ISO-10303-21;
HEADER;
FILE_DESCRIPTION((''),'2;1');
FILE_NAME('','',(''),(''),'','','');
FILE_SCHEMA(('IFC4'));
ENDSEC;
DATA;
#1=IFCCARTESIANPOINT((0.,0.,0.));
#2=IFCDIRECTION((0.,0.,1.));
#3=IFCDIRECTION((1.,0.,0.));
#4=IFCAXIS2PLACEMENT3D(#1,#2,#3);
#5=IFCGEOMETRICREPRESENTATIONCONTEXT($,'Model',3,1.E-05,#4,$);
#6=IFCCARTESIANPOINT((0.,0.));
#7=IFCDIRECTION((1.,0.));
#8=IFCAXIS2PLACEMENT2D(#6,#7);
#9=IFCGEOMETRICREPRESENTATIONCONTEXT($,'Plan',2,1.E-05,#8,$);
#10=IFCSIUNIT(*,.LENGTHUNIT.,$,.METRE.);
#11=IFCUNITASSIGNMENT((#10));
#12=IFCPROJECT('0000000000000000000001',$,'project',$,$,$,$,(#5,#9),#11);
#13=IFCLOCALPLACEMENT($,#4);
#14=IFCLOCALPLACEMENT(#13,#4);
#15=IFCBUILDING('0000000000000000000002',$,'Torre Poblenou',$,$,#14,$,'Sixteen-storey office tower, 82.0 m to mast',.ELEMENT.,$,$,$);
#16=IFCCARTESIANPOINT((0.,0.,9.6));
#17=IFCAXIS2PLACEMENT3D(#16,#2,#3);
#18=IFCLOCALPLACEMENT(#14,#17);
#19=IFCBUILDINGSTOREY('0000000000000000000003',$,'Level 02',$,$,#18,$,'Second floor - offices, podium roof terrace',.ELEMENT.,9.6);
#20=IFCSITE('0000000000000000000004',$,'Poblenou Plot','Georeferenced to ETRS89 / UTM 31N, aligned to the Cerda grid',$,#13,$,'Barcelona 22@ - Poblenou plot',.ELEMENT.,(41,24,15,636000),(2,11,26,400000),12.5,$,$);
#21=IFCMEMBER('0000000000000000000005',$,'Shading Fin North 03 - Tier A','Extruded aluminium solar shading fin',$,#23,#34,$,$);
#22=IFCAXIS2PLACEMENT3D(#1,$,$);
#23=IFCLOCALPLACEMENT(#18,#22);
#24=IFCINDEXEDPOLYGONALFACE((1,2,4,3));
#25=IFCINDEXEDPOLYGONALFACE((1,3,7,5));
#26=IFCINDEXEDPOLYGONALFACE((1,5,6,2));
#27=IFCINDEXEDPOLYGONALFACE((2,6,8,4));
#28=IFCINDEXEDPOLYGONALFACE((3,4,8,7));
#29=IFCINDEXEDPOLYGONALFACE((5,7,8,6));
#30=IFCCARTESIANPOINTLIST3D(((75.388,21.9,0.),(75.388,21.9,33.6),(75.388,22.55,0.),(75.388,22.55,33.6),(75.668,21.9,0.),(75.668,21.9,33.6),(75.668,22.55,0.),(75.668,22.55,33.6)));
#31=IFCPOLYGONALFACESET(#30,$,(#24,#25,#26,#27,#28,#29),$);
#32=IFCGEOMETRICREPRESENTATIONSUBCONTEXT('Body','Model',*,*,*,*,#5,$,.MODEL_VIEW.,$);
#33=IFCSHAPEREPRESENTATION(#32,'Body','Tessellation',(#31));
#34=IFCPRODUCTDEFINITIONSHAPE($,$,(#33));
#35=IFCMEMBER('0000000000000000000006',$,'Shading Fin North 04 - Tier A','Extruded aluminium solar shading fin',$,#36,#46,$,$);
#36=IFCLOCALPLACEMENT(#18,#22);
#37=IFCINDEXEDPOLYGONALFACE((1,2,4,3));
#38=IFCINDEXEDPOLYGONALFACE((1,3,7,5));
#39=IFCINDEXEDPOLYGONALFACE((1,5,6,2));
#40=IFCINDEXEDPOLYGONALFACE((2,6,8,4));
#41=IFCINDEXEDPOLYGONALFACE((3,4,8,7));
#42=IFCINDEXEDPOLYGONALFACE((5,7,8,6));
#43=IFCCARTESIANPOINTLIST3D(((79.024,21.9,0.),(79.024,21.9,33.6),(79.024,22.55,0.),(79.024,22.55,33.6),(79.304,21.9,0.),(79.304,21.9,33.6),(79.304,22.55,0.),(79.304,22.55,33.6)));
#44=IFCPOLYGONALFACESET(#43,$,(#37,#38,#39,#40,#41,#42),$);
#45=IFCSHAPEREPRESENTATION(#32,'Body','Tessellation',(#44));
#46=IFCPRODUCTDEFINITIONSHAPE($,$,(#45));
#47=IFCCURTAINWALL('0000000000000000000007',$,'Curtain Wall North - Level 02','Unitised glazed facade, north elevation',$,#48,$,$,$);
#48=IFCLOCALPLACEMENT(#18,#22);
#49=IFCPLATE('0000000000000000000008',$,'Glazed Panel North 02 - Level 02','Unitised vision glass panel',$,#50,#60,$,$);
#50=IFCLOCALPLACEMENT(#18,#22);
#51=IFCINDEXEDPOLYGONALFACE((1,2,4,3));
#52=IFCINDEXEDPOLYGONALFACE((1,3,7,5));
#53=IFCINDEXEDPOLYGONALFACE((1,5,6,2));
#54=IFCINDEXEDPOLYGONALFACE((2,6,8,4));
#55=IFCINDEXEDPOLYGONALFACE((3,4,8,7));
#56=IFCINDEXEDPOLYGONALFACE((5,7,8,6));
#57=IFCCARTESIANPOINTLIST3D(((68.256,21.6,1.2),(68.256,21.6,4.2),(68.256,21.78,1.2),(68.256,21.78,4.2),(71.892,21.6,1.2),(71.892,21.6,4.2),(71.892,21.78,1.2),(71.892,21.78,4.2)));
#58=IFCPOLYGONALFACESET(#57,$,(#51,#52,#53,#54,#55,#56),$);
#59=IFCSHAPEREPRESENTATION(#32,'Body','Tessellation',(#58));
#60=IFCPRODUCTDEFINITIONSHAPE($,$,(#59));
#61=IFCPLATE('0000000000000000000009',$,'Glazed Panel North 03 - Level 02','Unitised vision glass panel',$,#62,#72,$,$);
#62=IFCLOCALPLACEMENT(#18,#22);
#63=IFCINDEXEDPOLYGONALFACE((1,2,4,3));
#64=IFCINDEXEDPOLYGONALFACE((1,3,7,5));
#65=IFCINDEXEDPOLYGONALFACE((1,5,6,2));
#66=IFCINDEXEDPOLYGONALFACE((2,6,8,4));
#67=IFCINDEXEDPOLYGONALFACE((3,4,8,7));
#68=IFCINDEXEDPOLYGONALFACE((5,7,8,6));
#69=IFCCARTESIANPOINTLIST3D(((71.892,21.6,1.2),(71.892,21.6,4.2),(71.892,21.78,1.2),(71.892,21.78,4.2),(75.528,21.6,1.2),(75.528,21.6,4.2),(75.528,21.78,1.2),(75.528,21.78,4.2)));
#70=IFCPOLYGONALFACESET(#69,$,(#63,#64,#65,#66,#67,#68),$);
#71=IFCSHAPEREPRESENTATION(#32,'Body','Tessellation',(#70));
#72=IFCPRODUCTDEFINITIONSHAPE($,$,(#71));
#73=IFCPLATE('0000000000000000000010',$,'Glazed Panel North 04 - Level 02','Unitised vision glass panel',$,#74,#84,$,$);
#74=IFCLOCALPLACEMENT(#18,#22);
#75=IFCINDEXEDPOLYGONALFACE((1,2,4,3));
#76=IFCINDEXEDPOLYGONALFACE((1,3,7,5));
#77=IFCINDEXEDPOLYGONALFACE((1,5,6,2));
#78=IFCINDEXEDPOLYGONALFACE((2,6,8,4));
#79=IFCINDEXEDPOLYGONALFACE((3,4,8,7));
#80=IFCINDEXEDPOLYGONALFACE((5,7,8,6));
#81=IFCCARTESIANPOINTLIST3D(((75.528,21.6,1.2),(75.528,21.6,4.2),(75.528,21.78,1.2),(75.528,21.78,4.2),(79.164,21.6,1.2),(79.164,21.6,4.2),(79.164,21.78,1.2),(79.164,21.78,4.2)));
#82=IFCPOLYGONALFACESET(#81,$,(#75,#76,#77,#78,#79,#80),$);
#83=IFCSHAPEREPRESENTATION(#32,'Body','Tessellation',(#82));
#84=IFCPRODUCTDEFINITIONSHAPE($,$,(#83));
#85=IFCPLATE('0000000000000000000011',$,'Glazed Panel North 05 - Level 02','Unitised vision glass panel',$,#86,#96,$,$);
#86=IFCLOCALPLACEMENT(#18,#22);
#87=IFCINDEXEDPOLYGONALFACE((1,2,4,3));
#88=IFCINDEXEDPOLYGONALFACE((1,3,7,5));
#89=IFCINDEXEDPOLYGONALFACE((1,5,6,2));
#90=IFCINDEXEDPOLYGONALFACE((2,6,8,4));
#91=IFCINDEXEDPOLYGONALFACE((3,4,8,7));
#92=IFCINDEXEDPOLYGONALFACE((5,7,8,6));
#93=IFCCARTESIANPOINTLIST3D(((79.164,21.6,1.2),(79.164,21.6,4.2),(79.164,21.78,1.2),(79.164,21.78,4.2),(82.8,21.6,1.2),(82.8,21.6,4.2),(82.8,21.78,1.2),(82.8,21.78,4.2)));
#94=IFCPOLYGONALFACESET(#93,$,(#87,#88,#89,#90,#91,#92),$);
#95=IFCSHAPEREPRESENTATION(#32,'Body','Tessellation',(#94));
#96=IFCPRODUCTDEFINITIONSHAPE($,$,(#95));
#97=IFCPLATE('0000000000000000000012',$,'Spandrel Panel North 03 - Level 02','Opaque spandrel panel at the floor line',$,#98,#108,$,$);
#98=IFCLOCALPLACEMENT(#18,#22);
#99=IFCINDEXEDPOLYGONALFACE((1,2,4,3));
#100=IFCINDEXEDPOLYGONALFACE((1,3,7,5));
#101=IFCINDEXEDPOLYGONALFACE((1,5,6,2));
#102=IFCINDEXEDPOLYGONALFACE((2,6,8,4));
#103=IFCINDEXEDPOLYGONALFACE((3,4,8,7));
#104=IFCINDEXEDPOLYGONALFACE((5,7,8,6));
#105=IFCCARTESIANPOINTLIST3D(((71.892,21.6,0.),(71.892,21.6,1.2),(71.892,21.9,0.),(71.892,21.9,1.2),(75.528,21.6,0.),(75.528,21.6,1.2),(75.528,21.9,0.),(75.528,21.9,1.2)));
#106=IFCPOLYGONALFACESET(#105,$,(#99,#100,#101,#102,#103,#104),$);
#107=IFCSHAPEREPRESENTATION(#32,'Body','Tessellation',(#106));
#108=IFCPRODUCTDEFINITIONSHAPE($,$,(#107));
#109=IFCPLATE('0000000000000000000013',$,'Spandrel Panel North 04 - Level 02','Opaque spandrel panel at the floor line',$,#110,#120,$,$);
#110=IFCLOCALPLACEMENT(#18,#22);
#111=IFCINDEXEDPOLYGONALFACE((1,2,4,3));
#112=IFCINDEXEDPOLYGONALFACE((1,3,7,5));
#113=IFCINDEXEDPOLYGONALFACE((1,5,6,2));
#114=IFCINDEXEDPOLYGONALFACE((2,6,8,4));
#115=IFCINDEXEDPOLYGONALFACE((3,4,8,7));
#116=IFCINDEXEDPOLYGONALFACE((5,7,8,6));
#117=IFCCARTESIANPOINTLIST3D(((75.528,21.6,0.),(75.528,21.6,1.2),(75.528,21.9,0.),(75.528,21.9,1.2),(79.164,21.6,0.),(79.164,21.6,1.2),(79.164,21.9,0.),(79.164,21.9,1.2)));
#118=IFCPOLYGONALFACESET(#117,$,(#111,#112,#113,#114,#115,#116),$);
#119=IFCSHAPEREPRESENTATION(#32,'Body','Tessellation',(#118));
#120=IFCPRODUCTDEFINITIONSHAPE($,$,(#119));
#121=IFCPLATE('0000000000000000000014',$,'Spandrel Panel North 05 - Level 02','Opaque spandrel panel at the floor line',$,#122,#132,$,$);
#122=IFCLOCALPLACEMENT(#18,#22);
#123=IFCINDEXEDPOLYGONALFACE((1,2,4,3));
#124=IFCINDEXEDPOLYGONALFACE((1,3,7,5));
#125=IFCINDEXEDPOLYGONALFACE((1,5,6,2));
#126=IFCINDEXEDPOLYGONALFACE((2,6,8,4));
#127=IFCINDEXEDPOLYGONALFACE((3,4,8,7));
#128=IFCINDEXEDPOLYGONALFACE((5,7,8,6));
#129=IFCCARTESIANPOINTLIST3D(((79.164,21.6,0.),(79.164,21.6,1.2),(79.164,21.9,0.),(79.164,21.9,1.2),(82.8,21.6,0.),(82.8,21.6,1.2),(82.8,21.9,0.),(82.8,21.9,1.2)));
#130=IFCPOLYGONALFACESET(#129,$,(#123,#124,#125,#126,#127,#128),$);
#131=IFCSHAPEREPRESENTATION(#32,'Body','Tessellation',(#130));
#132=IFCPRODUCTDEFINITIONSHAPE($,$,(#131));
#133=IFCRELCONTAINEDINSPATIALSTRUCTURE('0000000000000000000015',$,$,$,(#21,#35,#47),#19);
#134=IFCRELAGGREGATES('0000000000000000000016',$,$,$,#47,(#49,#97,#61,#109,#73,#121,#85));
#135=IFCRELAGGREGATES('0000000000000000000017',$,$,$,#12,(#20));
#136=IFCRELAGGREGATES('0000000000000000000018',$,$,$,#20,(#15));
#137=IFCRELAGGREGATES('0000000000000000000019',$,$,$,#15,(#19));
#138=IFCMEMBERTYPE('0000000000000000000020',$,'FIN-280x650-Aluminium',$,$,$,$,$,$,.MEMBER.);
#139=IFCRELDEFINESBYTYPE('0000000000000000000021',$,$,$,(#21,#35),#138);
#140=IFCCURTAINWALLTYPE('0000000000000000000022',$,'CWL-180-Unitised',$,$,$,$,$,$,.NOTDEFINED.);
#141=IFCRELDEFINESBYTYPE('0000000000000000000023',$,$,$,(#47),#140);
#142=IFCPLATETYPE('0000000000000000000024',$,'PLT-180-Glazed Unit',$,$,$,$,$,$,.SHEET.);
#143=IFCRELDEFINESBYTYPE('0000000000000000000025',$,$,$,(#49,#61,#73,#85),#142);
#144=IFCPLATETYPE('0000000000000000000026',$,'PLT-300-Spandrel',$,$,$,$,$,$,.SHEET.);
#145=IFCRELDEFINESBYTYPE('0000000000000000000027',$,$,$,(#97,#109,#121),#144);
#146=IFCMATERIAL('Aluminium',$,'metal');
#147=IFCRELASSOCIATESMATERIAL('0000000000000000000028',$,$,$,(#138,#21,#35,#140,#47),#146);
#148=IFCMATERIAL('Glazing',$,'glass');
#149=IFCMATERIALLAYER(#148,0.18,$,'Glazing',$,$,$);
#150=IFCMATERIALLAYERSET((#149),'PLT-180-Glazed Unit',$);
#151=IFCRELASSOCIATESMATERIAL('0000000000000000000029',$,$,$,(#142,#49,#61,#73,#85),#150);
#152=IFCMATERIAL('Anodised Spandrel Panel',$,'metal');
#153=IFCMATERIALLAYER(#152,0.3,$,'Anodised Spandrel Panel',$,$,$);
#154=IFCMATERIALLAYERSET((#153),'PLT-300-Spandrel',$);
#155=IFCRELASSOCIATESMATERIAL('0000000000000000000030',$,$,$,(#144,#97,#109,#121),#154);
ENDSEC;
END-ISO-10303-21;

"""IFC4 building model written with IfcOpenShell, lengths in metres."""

from ifc_helpers import new_model, si_unit, frame, origin_with_axes, origin_2d_with_axis, place, context, subcontext, project, spatial, line, indexed_curve, rectangle, outline, extrude, material, layer, layer_set, layer_usage, material_profile, profile_set, profile_usage, type_object, element, aggregate, save


model = new_model("IFC4")

# Units and contexts
model_context = context("Model", 3, precision=1e-05, world=origin_with_axes())
plan_context = context("Plan", 2, precision=1e-05, world=origin_2d_with_axis())
body_context = subcontext(model_context, "Body", "Model", "MODEL_VIEW")
ifc_project = project(units=[si_unit("LENGTHUNIT", "METRE")], contexts=[model_context, plan_context])

# Site, building, storey
site_placement = place(None, origin_with_axes())
site = spatial("IfcSite", under=ifc_project, at=site_placement, Name="Poblenou Plot", Description="Georeferenced to ETRS89 / UTM 31N, aligned to the Cerda grid", LongName="Barcelona 22@ - Poblenou plot", CompositionType="ELEMENT", RefLatitude=(41, 24, 15, 636000), RefLongitude=(2, 11, 26, 400000), RefElevation=12.5)
building_placement = place(site_placement, origin_with_axes())
building = spatial("IfcBuilding", under=site, at=building_placement, Name="Torre Poblenou", LongName="Sixteen-storey office tower, 82.0 m to mast", CompositionType="ELEMENT")
storey_placement = place(building_placement, frame((0.0, 0.0, 9.6), z_axis=(0.0, 0.0, 1.0), x_axis=(1.0, 0.0, 0.0)))
storey = spatial("IfcBuildingStorey", under=building, at=storey_placement, Name="Level 02", LongName="Second floor - offices, podium roof terrace", CompositionType="ELEMENT", Elevation=9.6)

# Members
ifc_material_1 = material(Name="Aluminium", Category="metal")
ifc_material_profile_1 = material_profile(ifc_material_1, rectangle(XDim=0.28, YDim=0.65))
ifc_profile_set_1 = profile_set([ifc_material_profile_1], Name="FIN-280x650-Aluminium")
member_type = type_object("IfcMemberType", Name="FIN-280x650-Aluminium", PredefinedType="MEMBER", material=ifc_profile_set_1)
ifc_profile_usage_1 = profile_usage(ifc_profile_set_1)
member_1_placement = place(storey_placement, frame((75.388, 21.9, 0.0), z_axis=(0.0, 0.0, 1.0), x_axis=(1.0, 0.0, 0.0)))
element("IfcMember", 1, at=member_1_placement, inside=storey, type_object=member_type, material=ifc_profile_usage_1, Name="Shading Fin North 03 - Tier A", Description="Extruded aluminium solar shading fin", context=body_context, shape_type="SweptSolid", body=[
    extrude(outline(indexed_curve([(0.0, 0.0), (0.28, 0.0), (0.28, 0.65), (0.0, 0.65)], segments=[line(1, 2, 3, 4, 1)])), origin_with_axes(), (0.0, 0.0, 1.0), 33.6),
])
ifc_profile_usage_2 = profile_usage(ifc_profile_set_1)
member_2_placement = place(storey_placement, frame((79.024, 21.9, 0.0), z_axis=(0.0, 0.0, 1.0), x_axis=(1.0, 0.0, 0.0)))
element("IfcMember", 2, at=member_2_placement, inside=storey, type_object=member_type, material=ifc_profile_usage_2, Name="Shading Fin North 04 - Tier A", Description="Extruded aluminium solar shading fin", context=body_context, shape_type="SweptSolid", body=[
    extrude(outline(indexed_curve([(0.0, 0.0), (0.28, 0.0), (0.28, 0.65), (0.0, 0.65)], segments=[line(1, 2, 3, 4, 1)])), origin_with_axes(), (0.0, 0.0, 1.0), 33.6),
])

# Curtain wall, plates
curtain_wall_type = type_object("IfcCurtainWallType", Name="CWL-180-Unitised", PredefinedType="NOTDEFINED", material=ifc_material_1)
curtain_wall_placement = place(storey_placement, frame((64.62, 21.6, 0.0), z_axis=(0.0, 0.0, 1.0), x_axis=(1.0, 0.0, 0.0)))
curtain_wall = element("IfcCurtainWall", 3, at=curtain_wall_placement, inside=storey, type_object=curtain_wall_type, material=ifc_material_1, Name="Curtain Wall North - Level 02", Description="Unitised glazed facade, north elevation")
ifc_material_2 = material(Name="Glazing", Category="glass")
ifc_layer_1 = layer(ifc_material_2, 0.18, Name="Glazing")
ifc_layer_set_1 = layer_set([ifc_layer_1], Name="PLT-180-Glazed Unit")
ifc_layer_usage_1 = layer_usage(ifc_layer_set_1, "AXIS2", "POSITIVE", 0.0)
plate_type_1 = type_object("IfcPlateType", Name="PLT-180-Glazed Unit", PredefinedType="SHEET", material=ifc_layer_set_1)
plate_1_placement = place(curtain_wall_placement, frame((3.636, 0.0, 1.2), z_axis=(0.0, 0.0, 1.0), x_axis=(1.0, 0.0, 0.0)))
plate_1 = element("IfcPlate", 4, at=plate_1_placement, type_object=plate_type_1, material=ifc_layer_usage_1, Name="Glazed Panel North 02 - Level 02", Description="Unitised vision glass panel", context=body_context, shape_type="SweptSolid", body=[
    extrude(outline(indexed_curve([(0.0, 0.0), (3.636, 0.0), (3.636, 0.18), (0.0, 0.18)], segments=[line(1, 2, 3, 4, 1)])), origin_with_axes(), (0.0, 0.0, 1.0), 3.0),
])
ifc_layer_usage_2 = layer_usage(ifc_layer_set_1, "AXIS2", "POSITIVE", 0.0)
plate_2_placement = place(curtain_wall_placement, frame((7.272, 0.0, 1.2), z_axis=(0.0, 0.0, 1.0), x_axis=(1.0, 0.0, 0.0)))
plate_2 = element("IfcPlate", 5, at=plate_2_placement, type_object=plate_type_1, material=ifc_layer_usage_2, Name="Glazed Panel North 03 - Level 02", Description="Unitised vision glass panel", context=body_context, shape_type="SweptSolid", body=[
    extrude(outline(indexed_curve([(0.0, 0.0), (3.636, 0.0), (3.636, 0.18), (0.0, 0.18)], segments=[line(1, 2, 3, 4, 1)])), origin_with_axes(), (0.0, 0.0, 1.0), 3.0),
])
ifc_layer_usage_3 = layer_usage(ifc_layer_set_1, "AXIS2", "POSITIVE", 0.0)
plate_3_placement = place(curtain_wall_placement, frame((10.908, 0.0, 1.2), z_axis=(0.0, 0.0, 1.0), x_axis=(1.0, 0.0, 0.0)))
plate_3 = element("IfcPlate", 6, at=plate_3_placement, type_object=plate_type_1, material=ifc_layer_usage_3, Name="Glazed Panel North 04 - Level 02", Description="Unitised vision glass panel", context=body_context, shape_type="SweptSolid", body=[
    extrude(outline(indexed_curve([(0.0, 0.0), (3.636, 0.0), (3.636, 0.18), (0.0, 0.18)], segments=[line(1, 2, 3, 4, 1)])), origin_with_axes(), (0.0, 0.0, 1.0), 3.0),
])
ifc_layer_usage_4 = layer_usage(ifc_layer_set_1, "AXIS2", "POSITIVE", 0.0)
plate_4_placement = place(curtain_wall_placement, frame((14.544, 0.0, 1.2), z_axis=(0.0, 0.0, 1.0), x_axis=(1.0, 0.0, 0.0)))
plate_4 = element("IfcPlate", 7, at=plate_4_placement, type_object=plate_type_1, material=ifc_layer_usage_4, Name="Glazed Panel North 05 - Level 02", Description="Unitised vision glass panel", context=body_context, shape_type="SweptSolid", body=[
    extrude(outline(indexed_curve([(0.0, 0.0), (3.636, 0.0), (3.636, 0.18), (0.0, 0.18)], segments=[line(1, 2, 3, 4, 1)])), origin_with_axes(), (0.0, 0.0, 1.0), 3.0),
])
ifc_material_3 = material(Name="Anodised Spandrel Panel", Category="metal")
ifc_layer_2 = layer(ifc_material_3, 0.3, Name="Anodised Spandrel Panel")
ifc_layer_set_2 = layer_set([ifc_layer_2], Name="PLT-300-Spandrel")
ifc_layer_usage_5 = layer_usage(ifc_layer_set_2, "AXIS2", "POSITIVE", 0.0)
plate_type_2 = type_object("IfcPlateType", Name="PLT-300-Spandrel", PredefinedType="SHEET", material=ifc_layer_set_2)
plate_5_placement = place(curtain_wall_placement, frame((7.272, 0.0, 0.0), z_axis=(0.0, 0.0, 1.0), x_axis=(1.0, 0.0, 0.0)))
plate_5 = element("IfcPlate", 8, at=plate_5_placement, type_object=plate_type_2, material=ifc_layer_usage_5, Name="Spandrel Panel North 03 - Level 02", Description="Opaque spandrel panel at the floor line", context=body_context, shape_type="SweptSolid", body=[
    extrude(outline(indexed_curve([(0.0, 0.0), (3.636, 0.0), (3.636, 0.3), (0.0, 0.3)], segments=[line(1, 2, 3, 4, 1)])), origin_with_axes(), (0.0, 0.0, 1.0), 1.2),
])
ifc_layer_usage_6 = layer_usage(ifc_layer_set_2, "AXIS2", "POSITIVE", 0.0)
plate_6_placement = place(curtain_wall_placement, frame((10.908, 0.0, 0.0), z_axis=(0.0, 0.0, 1.0), x_axis=(1.0, 0.0, 0.0)))
plate_6 = element("IfcPlate", 9, at=plate_6_placement, type_object=plate_type_2, material=ifc_layer_usage_6, Name="Spandrel Panel North 04 - Level 02", Description="Opaque spandrel panel at the floor line", context=body_context, shape_type="SweptSolid", body=[
    extrude(outline(indexed_curve([(0.0, 0.0), (3.636, 0.0), (3.636, 0.3), (0.0, 0.3)], segments=[line(1, 2, 3, 4, 1)])), origin_with_axes(), (0.0, 0.0, 1.0), 1.2),
])
ifc_layer_usage_7 = layer_usage(ifc_layer_set_2, "AXIS2", "POSITIVE", 0.0)
plate_7_placement = place(curtain_wall_placement, frame((14.544, 0.0, 0.0), z_axis=(0.0, 0.0, 1.0), x_axis=(1.0, 0.0, 0.0)))
plate_7 = element("IfcPlate", 10, at=plate_7_placement, type_object=plate_type_2, material=ifc_layer_usage_7, Name="Spandrel Panel North 05 - Level 02", Description="Opaque spandrel panel at the floor line", context=body_context, shape_type="SweptSolid", body=[
    extrude(outline(indexed_curve([(0.0, 0.0), (3.636, 0.0), (3.636, 0.3), (0.0, 0.3)], segments=[line(1, 2, 3, 4, 1)])), origin_with_axes(), (0.0, 0.0, 1.0), 1.2),
])
aggregate(curtain_wall, [plate_1, plate_5, plate_2, plate_6, plate_3, plate_7, plate_4])

save(model, "model.ifc")
